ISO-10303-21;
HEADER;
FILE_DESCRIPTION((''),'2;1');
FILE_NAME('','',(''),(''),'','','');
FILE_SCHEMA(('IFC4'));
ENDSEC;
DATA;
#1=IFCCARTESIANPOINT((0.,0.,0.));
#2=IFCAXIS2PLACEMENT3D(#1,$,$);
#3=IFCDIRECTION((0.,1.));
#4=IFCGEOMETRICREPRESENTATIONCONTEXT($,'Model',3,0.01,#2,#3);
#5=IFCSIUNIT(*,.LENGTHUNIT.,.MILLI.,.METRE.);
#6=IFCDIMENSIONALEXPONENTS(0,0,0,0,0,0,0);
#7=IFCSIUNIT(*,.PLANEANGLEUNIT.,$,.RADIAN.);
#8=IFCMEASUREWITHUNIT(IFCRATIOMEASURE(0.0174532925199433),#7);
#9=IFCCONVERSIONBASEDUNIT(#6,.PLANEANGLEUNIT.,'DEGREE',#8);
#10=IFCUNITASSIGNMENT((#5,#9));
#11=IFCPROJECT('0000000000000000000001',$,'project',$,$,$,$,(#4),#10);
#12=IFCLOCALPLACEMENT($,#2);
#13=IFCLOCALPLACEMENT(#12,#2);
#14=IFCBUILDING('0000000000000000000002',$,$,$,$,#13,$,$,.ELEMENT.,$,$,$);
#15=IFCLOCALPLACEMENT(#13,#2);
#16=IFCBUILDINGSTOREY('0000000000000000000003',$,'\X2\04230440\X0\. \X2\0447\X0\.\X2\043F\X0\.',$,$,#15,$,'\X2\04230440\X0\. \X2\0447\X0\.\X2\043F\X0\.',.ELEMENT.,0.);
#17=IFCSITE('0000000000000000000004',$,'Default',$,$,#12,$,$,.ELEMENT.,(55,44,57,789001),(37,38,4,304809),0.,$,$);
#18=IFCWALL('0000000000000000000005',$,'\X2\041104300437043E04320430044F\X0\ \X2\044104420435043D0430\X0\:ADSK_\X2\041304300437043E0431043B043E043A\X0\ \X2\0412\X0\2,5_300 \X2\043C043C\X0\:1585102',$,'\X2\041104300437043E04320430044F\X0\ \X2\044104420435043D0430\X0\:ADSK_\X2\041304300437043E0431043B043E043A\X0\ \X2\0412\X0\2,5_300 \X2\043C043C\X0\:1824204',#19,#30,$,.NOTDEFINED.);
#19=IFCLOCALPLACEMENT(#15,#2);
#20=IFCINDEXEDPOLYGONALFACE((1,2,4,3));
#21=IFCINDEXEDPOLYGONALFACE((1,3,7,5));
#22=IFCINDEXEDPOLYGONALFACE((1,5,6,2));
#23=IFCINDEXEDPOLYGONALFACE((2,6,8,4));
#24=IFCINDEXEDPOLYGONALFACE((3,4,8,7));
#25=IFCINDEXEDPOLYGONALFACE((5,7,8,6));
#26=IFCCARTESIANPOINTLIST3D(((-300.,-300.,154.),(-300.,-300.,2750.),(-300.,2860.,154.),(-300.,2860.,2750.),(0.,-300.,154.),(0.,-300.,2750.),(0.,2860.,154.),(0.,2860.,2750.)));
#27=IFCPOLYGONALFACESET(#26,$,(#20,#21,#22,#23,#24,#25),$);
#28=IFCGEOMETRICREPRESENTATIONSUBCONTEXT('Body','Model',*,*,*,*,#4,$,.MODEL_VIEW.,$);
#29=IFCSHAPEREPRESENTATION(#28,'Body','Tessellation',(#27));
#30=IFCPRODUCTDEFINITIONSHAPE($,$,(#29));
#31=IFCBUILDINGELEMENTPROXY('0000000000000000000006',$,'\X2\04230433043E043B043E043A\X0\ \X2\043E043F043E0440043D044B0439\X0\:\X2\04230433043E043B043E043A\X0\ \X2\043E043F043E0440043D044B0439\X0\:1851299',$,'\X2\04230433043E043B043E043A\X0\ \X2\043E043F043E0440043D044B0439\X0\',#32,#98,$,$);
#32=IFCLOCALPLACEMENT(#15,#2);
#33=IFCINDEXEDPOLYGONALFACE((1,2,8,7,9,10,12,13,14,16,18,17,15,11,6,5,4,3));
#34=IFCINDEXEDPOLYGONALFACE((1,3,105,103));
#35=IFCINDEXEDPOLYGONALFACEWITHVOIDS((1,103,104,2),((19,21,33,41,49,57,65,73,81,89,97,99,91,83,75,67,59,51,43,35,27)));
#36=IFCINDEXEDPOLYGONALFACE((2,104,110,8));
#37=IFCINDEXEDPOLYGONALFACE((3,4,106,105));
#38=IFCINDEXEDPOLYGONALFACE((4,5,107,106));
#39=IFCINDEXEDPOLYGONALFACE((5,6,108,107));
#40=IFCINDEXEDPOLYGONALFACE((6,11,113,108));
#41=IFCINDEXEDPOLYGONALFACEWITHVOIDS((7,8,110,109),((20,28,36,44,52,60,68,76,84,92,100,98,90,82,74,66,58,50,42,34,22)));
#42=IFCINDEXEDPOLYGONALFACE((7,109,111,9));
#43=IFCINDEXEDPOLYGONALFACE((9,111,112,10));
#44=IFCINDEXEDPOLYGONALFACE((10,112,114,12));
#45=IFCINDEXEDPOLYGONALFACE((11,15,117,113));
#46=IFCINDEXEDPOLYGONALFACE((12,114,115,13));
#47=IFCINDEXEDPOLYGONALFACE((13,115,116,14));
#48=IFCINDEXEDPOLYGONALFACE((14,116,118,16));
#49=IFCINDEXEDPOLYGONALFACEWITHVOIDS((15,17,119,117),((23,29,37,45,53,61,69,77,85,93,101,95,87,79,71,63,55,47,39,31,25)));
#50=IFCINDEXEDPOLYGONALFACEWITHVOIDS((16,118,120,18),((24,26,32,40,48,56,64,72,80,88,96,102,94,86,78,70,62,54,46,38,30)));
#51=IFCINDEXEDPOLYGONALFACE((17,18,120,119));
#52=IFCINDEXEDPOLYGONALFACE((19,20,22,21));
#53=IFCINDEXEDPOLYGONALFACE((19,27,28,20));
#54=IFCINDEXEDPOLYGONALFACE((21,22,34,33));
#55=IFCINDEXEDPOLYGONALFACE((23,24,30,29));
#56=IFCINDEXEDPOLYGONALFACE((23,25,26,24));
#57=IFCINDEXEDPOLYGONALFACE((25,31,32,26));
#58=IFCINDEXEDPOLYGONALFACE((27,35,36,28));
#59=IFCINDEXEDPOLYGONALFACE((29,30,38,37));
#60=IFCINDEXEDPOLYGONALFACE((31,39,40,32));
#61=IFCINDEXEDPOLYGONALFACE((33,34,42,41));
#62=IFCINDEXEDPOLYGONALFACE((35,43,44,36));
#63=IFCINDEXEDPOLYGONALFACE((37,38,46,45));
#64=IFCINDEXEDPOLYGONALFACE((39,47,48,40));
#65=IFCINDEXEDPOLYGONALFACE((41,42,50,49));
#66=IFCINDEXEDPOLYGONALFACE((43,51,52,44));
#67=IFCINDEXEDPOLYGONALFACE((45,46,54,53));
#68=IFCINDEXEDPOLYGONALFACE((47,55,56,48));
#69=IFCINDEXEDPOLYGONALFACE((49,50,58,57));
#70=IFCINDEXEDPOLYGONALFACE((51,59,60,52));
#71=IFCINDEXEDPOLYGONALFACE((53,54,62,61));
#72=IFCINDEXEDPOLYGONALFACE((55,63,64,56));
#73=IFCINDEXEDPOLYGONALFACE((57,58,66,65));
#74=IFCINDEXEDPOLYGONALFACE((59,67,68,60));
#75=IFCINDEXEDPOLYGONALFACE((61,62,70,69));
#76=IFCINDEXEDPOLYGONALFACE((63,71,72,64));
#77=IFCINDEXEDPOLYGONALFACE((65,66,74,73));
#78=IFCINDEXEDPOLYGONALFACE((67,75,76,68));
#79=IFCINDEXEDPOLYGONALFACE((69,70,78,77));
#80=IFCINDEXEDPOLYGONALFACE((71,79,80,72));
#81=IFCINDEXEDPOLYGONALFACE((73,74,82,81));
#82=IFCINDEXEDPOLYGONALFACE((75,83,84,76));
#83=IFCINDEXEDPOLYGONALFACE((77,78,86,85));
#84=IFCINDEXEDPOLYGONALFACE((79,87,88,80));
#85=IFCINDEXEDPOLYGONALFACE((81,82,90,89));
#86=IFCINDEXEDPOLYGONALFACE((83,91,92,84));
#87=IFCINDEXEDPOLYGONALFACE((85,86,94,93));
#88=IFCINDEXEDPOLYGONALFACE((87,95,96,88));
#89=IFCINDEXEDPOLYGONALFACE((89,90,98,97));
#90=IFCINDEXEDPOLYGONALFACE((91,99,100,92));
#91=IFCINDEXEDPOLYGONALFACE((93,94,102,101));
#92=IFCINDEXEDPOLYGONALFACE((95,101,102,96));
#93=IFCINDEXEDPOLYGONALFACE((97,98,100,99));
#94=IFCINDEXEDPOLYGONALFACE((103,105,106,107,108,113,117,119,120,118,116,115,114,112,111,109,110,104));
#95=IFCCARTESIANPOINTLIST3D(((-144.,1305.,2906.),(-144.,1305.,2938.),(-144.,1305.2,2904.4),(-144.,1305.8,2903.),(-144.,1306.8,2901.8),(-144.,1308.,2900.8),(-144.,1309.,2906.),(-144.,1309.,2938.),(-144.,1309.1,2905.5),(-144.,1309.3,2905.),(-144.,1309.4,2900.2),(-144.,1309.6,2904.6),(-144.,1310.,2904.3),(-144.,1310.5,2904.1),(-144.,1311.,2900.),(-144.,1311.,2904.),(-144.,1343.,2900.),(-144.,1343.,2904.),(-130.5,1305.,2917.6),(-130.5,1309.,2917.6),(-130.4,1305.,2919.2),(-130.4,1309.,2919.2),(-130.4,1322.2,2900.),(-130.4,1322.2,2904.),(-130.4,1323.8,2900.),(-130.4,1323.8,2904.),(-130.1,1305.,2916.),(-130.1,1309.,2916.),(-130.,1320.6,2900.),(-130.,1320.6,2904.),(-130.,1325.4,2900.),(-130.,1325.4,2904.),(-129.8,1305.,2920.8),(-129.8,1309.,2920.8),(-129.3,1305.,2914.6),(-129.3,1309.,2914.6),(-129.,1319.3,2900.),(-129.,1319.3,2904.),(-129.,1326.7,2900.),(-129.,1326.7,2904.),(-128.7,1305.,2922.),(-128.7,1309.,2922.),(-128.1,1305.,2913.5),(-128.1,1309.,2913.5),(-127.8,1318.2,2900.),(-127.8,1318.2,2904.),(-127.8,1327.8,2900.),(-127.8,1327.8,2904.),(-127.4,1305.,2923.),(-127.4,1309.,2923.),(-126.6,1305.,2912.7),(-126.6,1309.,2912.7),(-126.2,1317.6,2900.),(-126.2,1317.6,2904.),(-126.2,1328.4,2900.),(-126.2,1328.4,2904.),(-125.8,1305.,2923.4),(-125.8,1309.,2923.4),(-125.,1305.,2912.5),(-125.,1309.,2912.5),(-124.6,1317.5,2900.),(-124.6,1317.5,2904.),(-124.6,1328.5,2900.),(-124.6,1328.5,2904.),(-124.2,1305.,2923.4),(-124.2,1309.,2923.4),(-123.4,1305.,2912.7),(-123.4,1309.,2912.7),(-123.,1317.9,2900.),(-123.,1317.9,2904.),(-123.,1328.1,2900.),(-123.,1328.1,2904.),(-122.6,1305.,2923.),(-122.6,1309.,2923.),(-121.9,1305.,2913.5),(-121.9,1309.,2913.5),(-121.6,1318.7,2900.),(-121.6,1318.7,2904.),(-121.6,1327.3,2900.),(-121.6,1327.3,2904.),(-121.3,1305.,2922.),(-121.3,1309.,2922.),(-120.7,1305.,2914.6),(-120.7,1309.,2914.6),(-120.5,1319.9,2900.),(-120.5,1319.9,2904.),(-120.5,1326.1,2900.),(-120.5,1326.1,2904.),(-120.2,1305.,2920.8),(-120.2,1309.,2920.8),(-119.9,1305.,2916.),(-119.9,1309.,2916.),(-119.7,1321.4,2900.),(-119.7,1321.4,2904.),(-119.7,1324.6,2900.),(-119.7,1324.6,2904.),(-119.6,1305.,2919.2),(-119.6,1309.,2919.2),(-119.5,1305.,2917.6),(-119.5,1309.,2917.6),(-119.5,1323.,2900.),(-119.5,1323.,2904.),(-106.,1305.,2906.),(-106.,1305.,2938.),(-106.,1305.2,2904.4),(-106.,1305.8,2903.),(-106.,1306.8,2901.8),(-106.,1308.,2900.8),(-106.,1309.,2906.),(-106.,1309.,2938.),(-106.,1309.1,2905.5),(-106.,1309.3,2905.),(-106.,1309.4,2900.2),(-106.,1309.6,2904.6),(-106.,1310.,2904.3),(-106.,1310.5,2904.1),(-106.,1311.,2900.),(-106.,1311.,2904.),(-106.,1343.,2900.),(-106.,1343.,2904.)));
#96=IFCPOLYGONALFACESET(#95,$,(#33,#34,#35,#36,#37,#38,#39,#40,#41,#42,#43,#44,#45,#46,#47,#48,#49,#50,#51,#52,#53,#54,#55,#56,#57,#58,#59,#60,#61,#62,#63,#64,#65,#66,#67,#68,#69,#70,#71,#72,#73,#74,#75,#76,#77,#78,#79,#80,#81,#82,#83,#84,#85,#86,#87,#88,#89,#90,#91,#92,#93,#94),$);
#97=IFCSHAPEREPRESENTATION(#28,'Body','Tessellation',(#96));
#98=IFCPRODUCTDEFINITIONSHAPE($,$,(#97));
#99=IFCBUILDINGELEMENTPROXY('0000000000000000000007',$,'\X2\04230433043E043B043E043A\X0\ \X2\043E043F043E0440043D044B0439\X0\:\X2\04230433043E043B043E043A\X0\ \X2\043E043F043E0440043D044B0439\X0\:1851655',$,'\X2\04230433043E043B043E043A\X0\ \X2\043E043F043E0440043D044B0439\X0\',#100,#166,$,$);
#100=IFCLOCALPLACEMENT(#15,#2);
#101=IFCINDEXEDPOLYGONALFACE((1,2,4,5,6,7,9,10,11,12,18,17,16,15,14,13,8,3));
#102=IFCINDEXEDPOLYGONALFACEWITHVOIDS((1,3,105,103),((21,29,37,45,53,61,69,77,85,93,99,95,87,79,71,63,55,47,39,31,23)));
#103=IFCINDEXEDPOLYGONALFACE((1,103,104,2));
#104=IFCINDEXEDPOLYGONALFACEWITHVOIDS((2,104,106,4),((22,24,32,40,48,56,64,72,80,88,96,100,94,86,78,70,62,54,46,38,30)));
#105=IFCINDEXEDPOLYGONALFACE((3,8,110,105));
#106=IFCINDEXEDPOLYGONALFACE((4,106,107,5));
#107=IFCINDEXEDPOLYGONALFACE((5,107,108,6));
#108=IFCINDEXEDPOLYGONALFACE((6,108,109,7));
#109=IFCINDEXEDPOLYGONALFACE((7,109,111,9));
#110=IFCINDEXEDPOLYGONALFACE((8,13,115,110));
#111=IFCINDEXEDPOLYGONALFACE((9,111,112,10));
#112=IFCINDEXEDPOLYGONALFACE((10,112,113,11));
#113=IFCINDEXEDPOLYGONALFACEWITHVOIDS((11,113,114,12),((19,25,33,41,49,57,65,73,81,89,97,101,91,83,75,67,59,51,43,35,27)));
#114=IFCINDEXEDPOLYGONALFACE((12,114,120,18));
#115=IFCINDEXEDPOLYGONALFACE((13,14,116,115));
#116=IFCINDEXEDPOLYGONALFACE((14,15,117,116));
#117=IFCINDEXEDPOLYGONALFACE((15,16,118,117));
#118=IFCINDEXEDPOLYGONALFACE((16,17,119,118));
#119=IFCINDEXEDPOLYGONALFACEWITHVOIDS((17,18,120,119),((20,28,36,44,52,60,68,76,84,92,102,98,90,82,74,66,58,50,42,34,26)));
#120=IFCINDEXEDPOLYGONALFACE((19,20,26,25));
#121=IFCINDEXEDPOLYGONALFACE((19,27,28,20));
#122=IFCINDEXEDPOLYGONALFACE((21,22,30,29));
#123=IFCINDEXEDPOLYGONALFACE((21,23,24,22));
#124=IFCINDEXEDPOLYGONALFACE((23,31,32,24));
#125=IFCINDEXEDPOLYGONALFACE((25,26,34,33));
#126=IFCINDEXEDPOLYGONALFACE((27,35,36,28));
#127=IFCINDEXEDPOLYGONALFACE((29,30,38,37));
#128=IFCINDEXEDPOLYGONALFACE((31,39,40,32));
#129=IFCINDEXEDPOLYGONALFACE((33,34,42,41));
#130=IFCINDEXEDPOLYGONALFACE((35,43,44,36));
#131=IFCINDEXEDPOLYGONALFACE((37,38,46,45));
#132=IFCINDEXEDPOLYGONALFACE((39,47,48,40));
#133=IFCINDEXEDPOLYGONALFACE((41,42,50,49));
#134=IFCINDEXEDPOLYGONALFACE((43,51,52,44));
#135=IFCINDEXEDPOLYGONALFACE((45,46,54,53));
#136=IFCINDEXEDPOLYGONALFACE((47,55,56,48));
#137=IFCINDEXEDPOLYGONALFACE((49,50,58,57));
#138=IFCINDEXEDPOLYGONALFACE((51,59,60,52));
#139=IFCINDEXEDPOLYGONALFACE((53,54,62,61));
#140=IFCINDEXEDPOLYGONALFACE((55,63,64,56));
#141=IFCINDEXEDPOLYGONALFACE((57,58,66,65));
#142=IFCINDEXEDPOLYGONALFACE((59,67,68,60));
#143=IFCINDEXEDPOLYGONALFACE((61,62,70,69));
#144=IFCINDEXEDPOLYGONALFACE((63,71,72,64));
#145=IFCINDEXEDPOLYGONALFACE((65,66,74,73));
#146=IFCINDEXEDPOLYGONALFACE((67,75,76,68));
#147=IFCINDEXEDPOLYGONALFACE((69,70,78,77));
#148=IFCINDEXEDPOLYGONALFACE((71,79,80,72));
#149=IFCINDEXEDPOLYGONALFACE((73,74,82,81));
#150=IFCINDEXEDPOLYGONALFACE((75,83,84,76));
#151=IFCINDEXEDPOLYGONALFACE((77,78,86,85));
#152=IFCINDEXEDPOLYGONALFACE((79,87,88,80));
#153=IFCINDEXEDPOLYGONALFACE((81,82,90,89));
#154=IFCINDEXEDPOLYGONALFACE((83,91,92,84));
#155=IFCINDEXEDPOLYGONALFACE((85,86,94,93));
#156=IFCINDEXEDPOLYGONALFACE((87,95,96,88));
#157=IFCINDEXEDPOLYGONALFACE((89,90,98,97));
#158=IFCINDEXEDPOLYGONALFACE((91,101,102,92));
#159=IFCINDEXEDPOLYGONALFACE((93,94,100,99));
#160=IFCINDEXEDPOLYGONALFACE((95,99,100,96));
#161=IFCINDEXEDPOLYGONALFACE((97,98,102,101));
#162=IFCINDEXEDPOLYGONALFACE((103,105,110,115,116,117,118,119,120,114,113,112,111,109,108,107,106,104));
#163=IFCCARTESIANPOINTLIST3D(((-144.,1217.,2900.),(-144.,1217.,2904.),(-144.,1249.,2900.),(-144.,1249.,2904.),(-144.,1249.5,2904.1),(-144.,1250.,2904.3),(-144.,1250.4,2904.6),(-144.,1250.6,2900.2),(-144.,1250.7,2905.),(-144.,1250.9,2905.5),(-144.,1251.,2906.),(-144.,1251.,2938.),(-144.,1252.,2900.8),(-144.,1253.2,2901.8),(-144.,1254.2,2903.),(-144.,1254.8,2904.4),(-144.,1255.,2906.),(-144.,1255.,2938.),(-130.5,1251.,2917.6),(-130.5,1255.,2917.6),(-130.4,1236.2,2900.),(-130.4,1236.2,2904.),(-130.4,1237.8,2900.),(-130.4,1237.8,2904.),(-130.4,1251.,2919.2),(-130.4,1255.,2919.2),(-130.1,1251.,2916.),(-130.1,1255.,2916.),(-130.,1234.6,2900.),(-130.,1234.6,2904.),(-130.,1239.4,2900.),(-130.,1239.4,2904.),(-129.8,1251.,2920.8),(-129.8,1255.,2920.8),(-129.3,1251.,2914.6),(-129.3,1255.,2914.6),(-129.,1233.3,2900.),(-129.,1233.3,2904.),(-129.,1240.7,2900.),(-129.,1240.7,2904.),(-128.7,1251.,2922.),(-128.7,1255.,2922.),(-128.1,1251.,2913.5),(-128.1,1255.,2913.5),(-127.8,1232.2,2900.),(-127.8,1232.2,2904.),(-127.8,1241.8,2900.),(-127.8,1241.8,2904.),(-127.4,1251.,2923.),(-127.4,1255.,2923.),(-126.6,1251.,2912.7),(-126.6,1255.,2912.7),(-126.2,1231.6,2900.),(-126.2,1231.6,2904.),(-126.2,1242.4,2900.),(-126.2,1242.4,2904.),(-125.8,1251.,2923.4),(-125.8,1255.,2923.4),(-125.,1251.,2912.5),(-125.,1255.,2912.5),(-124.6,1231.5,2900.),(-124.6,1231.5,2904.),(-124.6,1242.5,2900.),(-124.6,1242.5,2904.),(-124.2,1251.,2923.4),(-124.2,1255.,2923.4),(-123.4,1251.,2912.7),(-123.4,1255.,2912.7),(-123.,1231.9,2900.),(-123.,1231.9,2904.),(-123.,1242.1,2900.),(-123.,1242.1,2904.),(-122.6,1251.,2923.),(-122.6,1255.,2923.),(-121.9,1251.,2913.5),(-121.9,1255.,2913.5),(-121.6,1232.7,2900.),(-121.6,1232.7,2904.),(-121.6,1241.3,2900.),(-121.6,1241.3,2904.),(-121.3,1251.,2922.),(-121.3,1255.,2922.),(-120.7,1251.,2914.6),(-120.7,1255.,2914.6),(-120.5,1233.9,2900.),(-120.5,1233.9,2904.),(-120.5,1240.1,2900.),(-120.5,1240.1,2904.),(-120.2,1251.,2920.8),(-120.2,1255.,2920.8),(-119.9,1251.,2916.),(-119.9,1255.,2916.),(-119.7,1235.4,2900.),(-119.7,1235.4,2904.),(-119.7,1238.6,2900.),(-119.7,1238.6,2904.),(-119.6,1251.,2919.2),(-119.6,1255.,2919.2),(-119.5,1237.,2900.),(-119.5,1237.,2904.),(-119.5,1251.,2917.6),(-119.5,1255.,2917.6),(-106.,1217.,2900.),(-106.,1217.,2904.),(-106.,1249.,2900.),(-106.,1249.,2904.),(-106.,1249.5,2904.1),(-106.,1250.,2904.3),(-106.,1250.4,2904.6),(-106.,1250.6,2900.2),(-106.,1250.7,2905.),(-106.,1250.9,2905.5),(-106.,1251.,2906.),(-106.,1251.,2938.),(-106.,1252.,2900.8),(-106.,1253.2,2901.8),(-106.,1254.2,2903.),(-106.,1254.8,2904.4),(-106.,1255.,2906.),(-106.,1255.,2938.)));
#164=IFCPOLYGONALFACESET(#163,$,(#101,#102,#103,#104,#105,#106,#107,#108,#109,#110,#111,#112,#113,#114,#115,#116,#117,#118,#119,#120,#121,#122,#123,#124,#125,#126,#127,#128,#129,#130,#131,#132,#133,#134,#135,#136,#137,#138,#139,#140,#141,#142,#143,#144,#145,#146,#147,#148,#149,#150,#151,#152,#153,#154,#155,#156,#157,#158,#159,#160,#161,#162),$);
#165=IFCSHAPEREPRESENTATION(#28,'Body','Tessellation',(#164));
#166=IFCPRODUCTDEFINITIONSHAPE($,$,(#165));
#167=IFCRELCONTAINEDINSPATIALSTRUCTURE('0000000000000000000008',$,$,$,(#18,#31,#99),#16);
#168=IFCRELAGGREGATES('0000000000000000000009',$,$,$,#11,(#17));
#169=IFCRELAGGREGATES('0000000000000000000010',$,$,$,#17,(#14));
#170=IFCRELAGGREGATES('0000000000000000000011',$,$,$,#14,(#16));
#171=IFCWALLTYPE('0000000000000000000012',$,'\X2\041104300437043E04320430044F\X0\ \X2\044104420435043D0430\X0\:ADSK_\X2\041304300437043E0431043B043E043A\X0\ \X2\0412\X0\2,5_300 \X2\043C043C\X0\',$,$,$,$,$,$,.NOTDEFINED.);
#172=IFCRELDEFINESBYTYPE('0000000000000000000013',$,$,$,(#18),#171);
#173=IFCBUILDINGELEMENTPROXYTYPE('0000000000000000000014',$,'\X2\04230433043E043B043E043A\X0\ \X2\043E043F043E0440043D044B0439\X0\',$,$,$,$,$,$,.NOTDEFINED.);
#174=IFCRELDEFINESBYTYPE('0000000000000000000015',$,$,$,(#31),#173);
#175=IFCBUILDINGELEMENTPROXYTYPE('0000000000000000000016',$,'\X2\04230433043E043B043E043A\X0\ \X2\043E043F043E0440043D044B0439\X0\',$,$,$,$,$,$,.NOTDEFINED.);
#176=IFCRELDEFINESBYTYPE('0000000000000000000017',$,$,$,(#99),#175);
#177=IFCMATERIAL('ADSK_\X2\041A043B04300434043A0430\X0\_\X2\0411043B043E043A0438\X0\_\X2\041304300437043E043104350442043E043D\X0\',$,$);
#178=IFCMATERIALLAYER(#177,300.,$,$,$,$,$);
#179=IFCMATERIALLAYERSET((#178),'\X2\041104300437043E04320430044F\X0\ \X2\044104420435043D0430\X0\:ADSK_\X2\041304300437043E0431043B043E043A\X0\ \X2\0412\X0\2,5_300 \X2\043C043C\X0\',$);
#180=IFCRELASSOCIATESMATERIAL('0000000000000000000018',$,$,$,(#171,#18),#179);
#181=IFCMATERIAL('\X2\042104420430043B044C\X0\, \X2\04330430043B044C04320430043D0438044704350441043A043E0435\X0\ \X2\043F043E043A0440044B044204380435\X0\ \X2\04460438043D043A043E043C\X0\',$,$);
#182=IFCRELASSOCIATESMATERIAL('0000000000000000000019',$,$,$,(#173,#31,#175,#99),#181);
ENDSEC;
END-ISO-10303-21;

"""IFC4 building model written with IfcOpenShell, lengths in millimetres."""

from ifc_helpers import new_model, entity, si_unit, converted_unit, direction, frame, frame_2d, origin, place, context, subcontext, project, spatial, polyline, circle_curve, parameter, trimmed, segment, composite_curve, rectangle, circle, outline, extrude, source, transform, mapped, material, layer, layer_set, layer_usage, type_object, type_shapes, element, save


model = new_model("IFC4")

# Units and contexts
model_context = context("Model", 3, precision=0.01, world=origin(), true_north=direction((0.0, 1.0)))
body_context = subcontext(model_context, "Body", "Model", "MODEL_VIEW")
ifc_project = project(units=[si_unit("LENGTHUNIT", "METRE", prefix="MILLI"), converted_unit("PLANEANGLEUNIT", "DEGREE", entity("IfcRatioMeasure", 0.0174532925199433), si_unit("PLANEANGLEUNIT", "RADIAN"), dimensions=[0, 0, 0, 0, 0, 0, 0])], contexts=[model_context])

# Site, building, storey
site_placement = place(None, origin())
site = spatial("IfcSite", under=ifc_project, at=site_placement, Name="Default", CompositionType="ELEMENT", RefLatitude=(55, 44, 57, 789001), RefLongitude=(37, 38, 4, 304809), RefElevation=0.0)
building_placement = place(site_placement, origin())
building = spatial("IfcBuilding", under=site, at=building_placement, CompositionType="ELEMENT")
storey_placement = place(building_placement, origin())
storey = spatial("IfcBuildingStorey", under=building, at=storey_placement, Name="Ур. ч.п.", LongName="Ур. ч.п.", CompositionType="ELEMENT", Elevation=0.0)

# Wall
ifc_material_1 = material(Name="ADSK_Кладка_Блоки_Газобетон")
ifc_layer = layer(ifc_material_1, 300.0)
ifc_layer_set = layer_set([ifc_layer], Name="Базовая стена:ADSK_Газоблок В2,5_300 мм")
ifc_layer_usage = layer_usage(ifc_layer_set, "AXIS2", "POSITIVE", -150.0)
wall_type = type_object("IfcWallType", Name="Базовая стена:ADSK_Газоблок В2,5_300 мм", PredefinedType="NOTDEFINED", material=ifc_layer_set)
wall_placement = place(storey_placement, frame((-150.0, 2860.0, 154.0), z_axis=(0.0, 0.0, 1.0), x_axis=(0.0, -1.0, 0.0)))
element("IfcWall", 1, at=wall_placement, inside=storey, type_object=wall_type, material=ifc_layer_usage, Name="Базовая стена:ADSK_Газоблок В2,5_300 мм:1585102", ObjectType="Базовая стена:ADSK_Газоблок В2,5_300 мм:1824204", PredefinedType="NOTDEFINED", context=body_context, shape_type="SweptSolid", body=[
    extrude(rectangle(XDim=3160.0, YDim=300.0, at=frame_2d((1580.0, 0.0), x_axis=(-1.0, 0.0))), origin(), (0.0, 0.0, 1.0), 2596.0),
])

# Building element proxies, openings
ifc_material_2 = material(Name="Сталь, гальваническое покрытие цинком")
building_element_proxy_type_1 = type_object("IfcBuildingElementProxyType", Name="Уголок опорный", material=ifc_material_2)
shared_shape_1 = source(origin(), body_context, "Body", "SweptSolid", [
    extrude(outline(composite_curve([segment(polyline([(-6.0, -12.0), (26.0, -12.0)]), True, "CONTINUOUS"), segment(polyline([(26.0, -12.0), (26.0, -8.0)]), True, "CONTINUOUS"), segment(polyline([(26.0, -8.0), (-6.0, -8.0)]), True, "CONTINUOUS"), segment(trimmed(circle_curve(frame_2d((-6.0, -6.0), x_axis=(0.0, -1.0)), 2.0), [parameter(270.0)], [parameter(0.0)], True, "PARAMETER"), False, "CONTINUOUS"), segment(polyline([(-8.0, -6.0), (-8.0, 26.0)]), True, "CONTINUOUS"), segment(polyline([(-8.0, 26.0), (-12.0, 26.0)]), True, "CONTINUOUS"), segment(polyline([(-12.0, 26.0), (-12.0, -6.0)]), True, "CONTINUOUS"), segment(trimmed(circle_curve(frame_2d((-6.0, -6.0), x_axis=(0.0, -1.0)), 6.0), [parameter(270.0)], [parameter(360.0)], True, "PARAMETER"), True, "CONTINUOUS")], self_intersect=False)), frame((12.0, -19.0, 12.0), z_axis=(0.0, 1.0, 0.0), x_axis=(0.0, 0.0, 1.0)), (0.0, 0.0, 1.0), 38.0),
])
type_shapes(building_element_proxy_type_1, [shared_shape_1])
proxy_1_placement = place(storey_placement, frame((-125.0, 1305.0, 2900.0), z_axis=(0.0, 0.0, 1.0), x_axis=(0.0, 1.0, 0.0)))
proxy_1 = element("IfcBuildingElementProxy", 2, at=proxy_1_placement, inside=storey, type_object=building_element_proxy_type_1, material=ifc_material_2, Name="Уголок опорный:Уголок опорный:1851299", ObjectType="Уголок опорный", context=body_context, shape_type="MappedRepresentation", body=[
    mapped(shared_shape_1, transform((0.0, 0.0, 0.0), scale=1.0)),
])
opening_1_placement = place(storey_placement, frame((-125.0, 1305.0, 2900.0), z_axis=(0.0, 0.0, 1.0), x_axis=(-1.0, 0.0, 0.0)))
element("IfcOpeningElement", 3, at=opening_1_placement, cuts=proxy_1, ObjectType="Opening", PredefinedType="OPENING", context=body_context, shape_type="SweptSolid", body=[
    extrude(circle(Radius=5.5, at=frame_2d((0.0, 0.0), x_axis=(1.0, 0.0))), frame((0.0, -4.0, 18.0), z_axis=(0.0, 1.0, 0.0), x_axis=(0.0, 0.0, -1.0)), (0.0, 0.0, 1.0), 4.0),
])
opening_2_placement = place(storey_placement, frame((-125.0, 1305.0, 2900.0), z_axis=(0.0, 0.0, 1.0), x_axis=(-1.0, 0.0, 0.0)))
element("IfcOpeningElement", 4, at=opening_2_placement, cuts=proxy_1, ObjectType="Opening", PredefinedType="OPENING", context=body_context, shape_type="SweptSolid", body=[
    extrude(circle(Radius=5.5, at=frame_2d((0.0, 0.0), x_axis=(1.0, 0.0))), frame((0.0, -18.0, 0.0), z_axis=(0.0, 0.0, 1.0), x_axis=(-1.0, 0.0, 0.0)), (0.0, 0.0, 1.0), 4.0),
])
building_element_proxy_type_2 = type_object("IfcBuildingElementProxyType", Name="Уголок опорный", material=ifc_material_2)
shared_shape_2 = source(origin(), body_context, "Body", "SweptSolid", [
    extrude(outline(composite_curve([segment(polyline([(-6.0, -12.0), (26.0, -12.0)]), True, "CONTINUOUS"), segment(polyline([(26.0, -12.0), (26.0, -8.0)]), True, "CONTINUOUS"), segment(polyline([(26.0, -8.0), (-6.0, -8.0)]), True, "CONTINUOUS"), segment(trimmed(circle_curve(frame_2d((-6.0, -6.0), x_axis=(0.0, -1.0)), 2.0), [parameter(270.0)], [parameter(0.0)], True, "PARAMETER"), False, "CONTINUOUS"), segment(polyline([(-8.0, -6.0), (-8.0, 26.0)]), True, "CONTINUOUS"), segment(polyline([(-8.0, 26.0), (-12.0, 26.0)]), True, "CONTINUOUS"), segment(polyline([(-12.0, 26.0), (-12.0, -6.0)]), True, "CONTINUOUS"), segment(trimmed(circle_curve(frame_2d((-6.0, -6.0), x_axis=(0.0, -1.0)), 6.0), [parameter(270.0)], [parameter(360.0)], True, "PARAMETER"), True, "CONTINUOUS")], self_intersect=False)), frame((12.0, -19.0, 12.0), z_axis=(0.0, 1.0, 0.0), x_axis=(0.0, 0.0, 1.0)), (0.0, 0.0, 1.0), 38.0),
])
type_shapes(building_element_proxy_type_2, [shared_shape_2])
proxy_2_placement = place(storey_placement, frame((-125.0, 1255.0, 2900.0), z_axis=(0.0, 0.0, 1.0), x_axis=(0.0, -1.0, 0.0)))
proxy_2 = element("IfcBuildingElementProxy", 5, at=proxy_2_placement, inside=storey, type_object=building_element_proxy_type_2, material=ifc_material_2, Name="Уголок опорный:Уголок опорный:1851655", ObjectType="Уголок опорный", context=body_context, shape_type="MappedRepresentation", body=[
    mapped(shared_shape_2, transform((0.0, 0.0, 0.0), scale=1.0)),
])
opening_3_placement = place(storey_placement, frame((-125.0, 1255.0, 2900.0), z_axis=(0.0, 0.0, 1.0), x_axis=(-1.0, 0.0, 0.0)))
element("IfcOpeningElement", 6, at=opening_3_placement, cuts=proxy_2, ObjectType="Opening", PredefinedType="OPENING", context=body_context, shape_type="SweptSolid", body=[
    extrude(circle(Radius=5.5, at=frame_2d((0.0, 0.0), x_axis=(1.0, 0.0))), frame((0.0, 0.0, 18.0), z_axis=(0.0, 1.0, 0.0), x_axis=(0.0, 0.0, -1.0)), (0.0, 0.0, 1.0), 4.0),
])
opening_4_placement = place(storey_placement, frame((-125.0, 1255.0, 2900.0), z_axis=(0.0, 0.0, 1.0), x_axis=(-1.0, 0.0, 0.0)))
element("IfcOpeningElement", 7, at=opening_4_placement, cuts=proxy_2, ObjectType="Opening", PredefinedType="OPENING", context=body_context, shape_type="SweptSolid", body=[
    extrude(circle(Radius=5.5, at=frame_2d((0.0, 0.0), x_axis=(1.0, 0.0))), frame((0.0, 18.0, 0.0), z_axis=(0.0, 0.0, 1.0), x_axis=(-1.0, 0.0, 0.0)), (0.0, 0.0, 1.0), 4.0),
])

save(model, "model.ifc")
